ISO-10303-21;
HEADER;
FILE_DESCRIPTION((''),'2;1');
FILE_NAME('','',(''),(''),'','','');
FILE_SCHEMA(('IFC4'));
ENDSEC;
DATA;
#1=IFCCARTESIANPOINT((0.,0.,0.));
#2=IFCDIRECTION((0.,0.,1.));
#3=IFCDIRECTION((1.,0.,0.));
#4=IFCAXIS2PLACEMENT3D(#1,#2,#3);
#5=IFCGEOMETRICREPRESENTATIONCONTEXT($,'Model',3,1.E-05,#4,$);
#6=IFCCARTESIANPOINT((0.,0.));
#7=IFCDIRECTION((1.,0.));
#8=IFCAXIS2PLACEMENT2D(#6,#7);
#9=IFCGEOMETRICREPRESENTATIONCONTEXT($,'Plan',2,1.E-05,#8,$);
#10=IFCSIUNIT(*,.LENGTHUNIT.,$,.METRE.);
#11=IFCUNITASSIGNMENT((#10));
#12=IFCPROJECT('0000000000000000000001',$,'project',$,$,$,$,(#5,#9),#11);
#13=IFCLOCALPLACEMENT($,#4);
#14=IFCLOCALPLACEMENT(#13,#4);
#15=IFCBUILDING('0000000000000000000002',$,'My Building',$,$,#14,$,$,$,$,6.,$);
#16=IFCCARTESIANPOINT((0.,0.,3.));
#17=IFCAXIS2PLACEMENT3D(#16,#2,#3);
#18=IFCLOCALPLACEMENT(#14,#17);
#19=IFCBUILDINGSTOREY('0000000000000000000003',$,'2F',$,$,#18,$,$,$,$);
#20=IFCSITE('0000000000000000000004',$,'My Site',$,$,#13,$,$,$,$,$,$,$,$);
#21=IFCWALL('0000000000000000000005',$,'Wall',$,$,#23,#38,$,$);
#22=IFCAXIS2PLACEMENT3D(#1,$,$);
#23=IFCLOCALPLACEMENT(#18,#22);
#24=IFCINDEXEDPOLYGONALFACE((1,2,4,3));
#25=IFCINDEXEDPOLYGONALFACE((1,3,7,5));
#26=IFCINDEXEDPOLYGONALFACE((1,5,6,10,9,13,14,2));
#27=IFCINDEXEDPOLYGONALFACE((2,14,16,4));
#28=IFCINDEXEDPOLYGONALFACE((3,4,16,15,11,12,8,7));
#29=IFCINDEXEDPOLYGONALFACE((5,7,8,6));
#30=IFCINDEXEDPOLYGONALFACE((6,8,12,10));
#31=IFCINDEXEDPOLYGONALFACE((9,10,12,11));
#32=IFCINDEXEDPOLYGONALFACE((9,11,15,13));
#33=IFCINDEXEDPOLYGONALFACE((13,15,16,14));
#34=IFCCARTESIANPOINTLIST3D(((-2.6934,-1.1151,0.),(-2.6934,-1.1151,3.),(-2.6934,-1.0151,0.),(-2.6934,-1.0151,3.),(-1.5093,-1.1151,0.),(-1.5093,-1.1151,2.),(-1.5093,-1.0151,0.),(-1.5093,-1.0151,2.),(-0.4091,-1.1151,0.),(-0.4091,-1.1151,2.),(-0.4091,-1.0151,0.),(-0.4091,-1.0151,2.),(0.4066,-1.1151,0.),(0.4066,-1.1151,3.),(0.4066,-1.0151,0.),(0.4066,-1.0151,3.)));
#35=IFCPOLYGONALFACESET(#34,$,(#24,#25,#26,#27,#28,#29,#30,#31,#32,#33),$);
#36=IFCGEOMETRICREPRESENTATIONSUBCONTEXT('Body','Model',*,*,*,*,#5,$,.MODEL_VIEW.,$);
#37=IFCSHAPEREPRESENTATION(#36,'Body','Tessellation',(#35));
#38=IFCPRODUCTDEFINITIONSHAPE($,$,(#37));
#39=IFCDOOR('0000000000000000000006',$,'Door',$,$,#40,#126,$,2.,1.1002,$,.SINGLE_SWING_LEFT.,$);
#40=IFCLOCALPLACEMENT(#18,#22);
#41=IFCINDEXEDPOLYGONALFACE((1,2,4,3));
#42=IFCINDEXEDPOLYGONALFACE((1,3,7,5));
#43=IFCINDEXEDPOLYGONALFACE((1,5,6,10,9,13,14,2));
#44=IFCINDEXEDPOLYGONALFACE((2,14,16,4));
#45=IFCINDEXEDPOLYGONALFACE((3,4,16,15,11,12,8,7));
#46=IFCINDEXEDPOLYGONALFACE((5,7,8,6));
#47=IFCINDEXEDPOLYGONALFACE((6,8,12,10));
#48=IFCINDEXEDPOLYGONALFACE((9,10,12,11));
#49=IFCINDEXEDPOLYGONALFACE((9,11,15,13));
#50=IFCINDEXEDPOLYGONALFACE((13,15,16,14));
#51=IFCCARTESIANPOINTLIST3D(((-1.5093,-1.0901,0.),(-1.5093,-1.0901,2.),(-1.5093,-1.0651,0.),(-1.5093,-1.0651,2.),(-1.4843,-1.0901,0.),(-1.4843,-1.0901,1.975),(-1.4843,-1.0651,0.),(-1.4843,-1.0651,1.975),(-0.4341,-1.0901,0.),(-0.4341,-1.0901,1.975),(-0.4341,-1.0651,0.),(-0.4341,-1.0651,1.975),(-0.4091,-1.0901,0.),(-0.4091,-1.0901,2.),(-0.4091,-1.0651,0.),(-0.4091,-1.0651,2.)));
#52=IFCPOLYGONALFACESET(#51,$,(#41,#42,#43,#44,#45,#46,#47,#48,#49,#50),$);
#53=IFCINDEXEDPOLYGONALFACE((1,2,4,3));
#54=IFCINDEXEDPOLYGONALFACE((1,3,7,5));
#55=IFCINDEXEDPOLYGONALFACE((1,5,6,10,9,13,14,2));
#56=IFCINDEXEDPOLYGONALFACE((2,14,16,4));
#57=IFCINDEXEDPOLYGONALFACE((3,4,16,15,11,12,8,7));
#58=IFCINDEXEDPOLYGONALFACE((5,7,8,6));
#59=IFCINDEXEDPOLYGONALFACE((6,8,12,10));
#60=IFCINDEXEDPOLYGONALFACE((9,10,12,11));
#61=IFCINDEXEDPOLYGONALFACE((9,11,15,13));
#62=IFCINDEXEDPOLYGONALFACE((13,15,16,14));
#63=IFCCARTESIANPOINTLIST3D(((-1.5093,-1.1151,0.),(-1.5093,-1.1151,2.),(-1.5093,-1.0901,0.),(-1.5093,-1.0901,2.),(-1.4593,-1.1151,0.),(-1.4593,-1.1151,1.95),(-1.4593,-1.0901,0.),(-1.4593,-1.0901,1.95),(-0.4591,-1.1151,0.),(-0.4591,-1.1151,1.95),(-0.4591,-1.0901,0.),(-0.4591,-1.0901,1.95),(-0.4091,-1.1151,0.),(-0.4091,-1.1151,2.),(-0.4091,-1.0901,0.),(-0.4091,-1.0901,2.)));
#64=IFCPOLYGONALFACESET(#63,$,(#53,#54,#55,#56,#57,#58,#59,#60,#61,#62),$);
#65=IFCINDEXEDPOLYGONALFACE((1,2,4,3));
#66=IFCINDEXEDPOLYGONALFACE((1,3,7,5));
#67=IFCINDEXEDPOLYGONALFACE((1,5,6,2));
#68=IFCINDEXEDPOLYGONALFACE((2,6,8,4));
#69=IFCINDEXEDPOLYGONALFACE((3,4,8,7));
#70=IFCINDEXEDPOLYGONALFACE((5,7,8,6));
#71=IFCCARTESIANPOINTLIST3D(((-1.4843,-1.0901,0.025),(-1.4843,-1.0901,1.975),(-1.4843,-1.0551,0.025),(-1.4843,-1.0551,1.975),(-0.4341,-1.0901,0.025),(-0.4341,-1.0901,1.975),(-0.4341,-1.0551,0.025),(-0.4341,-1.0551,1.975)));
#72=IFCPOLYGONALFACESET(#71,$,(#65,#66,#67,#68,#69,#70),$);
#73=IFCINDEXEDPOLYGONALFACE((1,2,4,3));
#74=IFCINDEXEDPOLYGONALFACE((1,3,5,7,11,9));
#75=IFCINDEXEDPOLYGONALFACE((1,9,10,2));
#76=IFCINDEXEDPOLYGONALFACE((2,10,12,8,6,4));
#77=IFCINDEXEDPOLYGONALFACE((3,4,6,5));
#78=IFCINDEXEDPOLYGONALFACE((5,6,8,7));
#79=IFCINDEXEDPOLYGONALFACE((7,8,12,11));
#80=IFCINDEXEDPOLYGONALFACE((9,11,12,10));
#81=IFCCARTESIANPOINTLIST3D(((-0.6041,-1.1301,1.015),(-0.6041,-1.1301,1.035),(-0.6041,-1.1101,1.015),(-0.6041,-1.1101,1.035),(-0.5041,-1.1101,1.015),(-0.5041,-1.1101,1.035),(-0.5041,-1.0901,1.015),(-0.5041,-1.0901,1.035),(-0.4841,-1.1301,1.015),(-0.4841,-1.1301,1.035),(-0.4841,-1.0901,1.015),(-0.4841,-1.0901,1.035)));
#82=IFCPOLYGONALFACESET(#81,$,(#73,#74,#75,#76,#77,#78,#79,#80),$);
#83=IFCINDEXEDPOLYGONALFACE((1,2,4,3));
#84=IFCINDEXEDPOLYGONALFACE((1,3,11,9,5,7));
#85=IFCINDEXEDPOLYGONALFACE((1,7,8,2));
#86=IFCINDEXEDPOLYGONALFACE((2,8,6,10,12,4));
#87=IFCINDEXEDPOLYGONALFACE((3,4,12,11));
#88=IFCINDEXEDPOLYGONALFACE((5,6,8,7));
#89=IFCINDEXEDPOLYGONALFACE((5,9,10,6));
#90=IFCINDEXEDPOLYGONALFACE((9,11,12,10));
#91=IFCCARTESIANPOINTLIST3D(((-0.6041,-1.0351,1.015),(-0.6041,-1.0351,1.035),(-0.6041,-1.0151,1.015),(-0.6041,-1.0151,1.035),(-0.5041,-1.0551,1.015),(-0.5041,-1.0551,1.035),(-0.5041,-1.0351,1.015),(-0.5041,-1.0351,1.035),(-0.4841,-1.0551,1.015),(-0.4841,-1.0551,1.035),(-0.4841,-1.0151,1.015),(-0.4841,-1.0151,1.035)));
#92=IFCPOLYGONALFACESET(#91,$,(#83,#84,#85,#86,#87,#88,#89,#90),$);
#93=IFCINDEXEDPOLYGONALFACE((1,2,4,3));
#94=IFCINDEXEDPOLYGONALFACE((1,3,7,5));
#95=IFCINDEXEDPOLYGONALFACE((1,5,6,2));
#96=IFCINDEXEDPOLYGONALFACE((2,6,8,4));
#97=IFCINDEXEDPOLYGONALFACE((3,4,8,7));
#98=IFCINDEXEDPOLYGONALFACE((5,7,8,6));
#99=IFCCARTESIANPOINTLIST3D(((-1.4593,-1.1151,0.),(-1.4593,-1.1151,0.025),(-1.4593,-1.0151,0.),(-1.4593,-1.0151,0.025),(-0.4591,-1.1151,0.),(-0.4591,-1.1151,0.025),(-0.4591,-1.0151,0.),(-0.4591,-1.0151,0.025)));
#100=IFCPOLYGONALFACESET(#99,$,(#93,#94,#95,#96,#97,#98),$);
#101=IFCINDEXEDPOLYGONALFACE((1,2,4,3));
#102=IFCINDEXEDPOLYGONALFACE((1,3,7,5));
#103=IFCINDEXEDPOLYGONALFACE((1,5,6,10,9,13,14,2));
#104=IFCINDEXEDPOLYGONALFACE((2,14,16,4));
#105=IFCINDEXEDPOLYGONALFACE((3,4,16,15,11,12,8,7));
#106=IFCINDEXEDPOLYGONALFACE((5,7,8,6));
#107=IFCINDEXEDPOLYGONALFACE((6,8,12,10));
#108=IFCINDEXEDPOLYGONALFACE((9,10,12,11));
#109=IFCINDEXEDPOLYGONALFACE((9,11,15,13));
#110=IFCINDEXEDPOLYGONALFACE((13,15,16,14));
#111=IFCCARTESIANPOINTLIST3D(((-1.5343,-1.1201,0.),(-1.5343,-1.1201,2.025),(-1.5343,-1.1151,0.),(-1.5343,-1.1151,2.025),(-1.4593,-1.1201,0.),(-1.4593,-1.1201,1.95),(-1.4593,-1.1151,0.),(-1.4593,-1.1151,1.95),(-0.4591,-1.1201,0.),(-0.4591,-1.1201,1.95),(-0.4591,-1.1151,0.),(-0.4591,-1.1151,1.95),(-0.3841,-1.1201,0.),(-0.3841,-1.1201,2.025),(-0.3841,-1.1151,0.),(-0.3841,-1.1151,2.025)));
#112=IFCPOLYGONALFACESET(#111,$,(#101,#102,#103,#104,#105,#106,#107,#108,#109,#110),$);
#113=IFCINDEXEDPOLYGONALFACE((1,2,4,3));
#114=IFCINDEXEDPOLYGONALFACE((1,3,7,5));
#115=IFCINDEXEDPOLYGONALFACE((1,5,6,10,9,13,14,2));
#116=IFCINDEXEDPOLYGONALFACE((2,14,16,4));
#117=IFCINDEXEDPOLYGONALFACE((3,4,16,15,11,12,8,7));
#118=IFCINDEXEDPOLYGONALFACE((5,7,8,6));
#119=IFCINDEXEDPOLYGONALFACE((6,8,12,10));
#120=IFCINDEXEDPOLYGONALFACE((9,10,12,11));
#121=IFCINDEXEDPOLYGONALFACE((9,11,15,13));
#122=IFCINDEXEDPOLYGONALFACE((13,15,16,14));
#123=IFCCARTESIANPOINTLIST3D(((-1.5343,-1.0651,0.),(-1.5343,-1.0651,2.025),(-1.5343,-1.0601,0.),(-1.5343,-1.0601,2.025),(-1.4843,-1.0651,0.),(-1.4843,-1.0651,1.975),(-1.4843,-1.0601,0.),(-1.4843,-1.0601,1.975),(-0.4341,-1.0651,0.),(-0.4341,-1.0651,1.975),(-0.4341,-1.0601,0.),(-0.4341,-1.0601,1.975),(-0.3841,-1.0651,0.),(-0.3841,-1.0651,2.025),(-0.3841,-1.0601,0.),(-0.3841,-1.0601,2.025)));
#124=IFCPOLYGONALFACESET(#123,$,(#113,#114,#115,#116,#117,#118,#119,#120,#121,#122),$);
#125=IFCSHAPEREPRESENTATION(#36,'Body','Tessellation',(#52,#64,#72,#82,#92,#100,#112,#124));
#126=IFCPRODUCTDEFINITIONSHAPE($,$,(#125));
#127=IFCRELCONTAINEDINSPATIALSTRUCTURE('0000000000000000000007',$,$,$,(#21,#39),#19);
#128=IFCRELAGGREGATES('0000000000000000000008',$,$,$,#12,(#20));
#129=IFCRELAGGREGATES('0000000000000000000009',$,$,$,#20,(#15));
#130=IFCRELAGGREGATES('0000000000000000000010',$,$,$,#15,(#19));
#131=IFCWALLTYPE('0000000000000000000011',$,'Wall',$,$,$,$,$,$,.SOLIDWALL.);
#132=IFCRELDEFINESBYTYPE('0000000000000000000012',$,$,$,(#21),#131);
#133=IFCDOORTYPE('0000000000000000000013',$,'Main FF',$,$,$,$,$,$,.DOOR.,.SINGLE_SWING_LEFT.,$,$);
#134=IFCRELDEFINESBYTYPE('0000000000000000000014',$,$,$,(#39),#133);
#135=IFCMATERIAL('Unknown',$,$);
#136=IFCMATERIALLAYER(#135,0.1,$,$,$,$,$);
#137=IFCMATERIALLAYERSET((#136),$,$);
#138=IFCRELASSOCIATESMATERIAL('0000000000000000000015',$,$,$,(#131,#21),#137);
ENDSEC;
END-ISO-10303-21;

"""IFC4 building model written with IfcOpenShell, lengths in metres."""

from ifc_helpers import new_model, entity, si_unit, frame, origin_with_axes, origin_2d_with_axis, place, context, subcontext, project, spatial, line, indexed_curve, outline, extrude, shape, source, transform, mapped, material, layer, layer_set, layer_usage, type_object, type_shapes, element, fill, save


model = new_model("IFC4")

# Units and contexts
model_context = context("Model", 3, precision=1e-05, world=origin_with_axes())
plan_context = context("Plan", 2, precision=1e-05, world=origin_2d_with_axis())
body_context_1 = subcontext(model_context, "Body", "Model", "MODEL_VIEW")
body_context_2 = subcontext(plan_context, "Body", "Plan", "PLAN_VIEW")
ifc_project = project(units=[si_unit("LENGTHUNIT", "METRE")], contexts=[model_context, plan_context])

# Site, building, storey
site_placement = place(None, origin_with_axes())
site = spatial("IfcSite", under=ifc_project, at=site_placement, Name="My Site")
building_placement = place(site_placement, origin_with_axes())
building = spatial("IfcBuilding", under=site, at=building_placement, Name="My Building", ElevationOfTerrain=6.0)
storey_placement = place(building_placement, frame((0.0, 0.0, 3.0), z_axis=(0.0, 0.0, 1.0), x_axis=(1.0, 0.0, 0.0)))
storey = spatial("IfcBuildingStorey", under=building, at=storey_placement, Name="2F")

# Shared definitions
ifc_material_1 = material(Name="Unknown")

# Shared definitions
ifc_layer_1 = layer(ifc_material_1, 0.1)
ifc_layer_set_1 = layer_set([ifc_layer_1])
wall_type = type_object("IfcWallType", Name="Wall", PredefinedType="SOLIDWALL", material=ifc_layer_set_1)

# Wall, opening, door
ifc_layer_usage_1 = layer_usage(ifc_layer_set_1, "AXIS2", "POSITIVE", 0.0)
wall_1_placement = place(storey_placement, frame((-2.6934, -1.1151, 0.0), z_axis=(0.0, 0.0, 1.0), x_axis=(1.0, 0.0, 0.0)))
wall_1 = element("IfcWall", 1, at=wall_1_placement, inside=storey, type_object=wall_type, material=ifc_layer_usage_1, Name="Wall", context=body_context_1, shape_type="SweptSolid", body=[
    extrude(outline(indexed_curve([(0.0, 0.0), (0.0, 0.1), (3.1, 0.1), (3.1, 0.0)], segments=[line(1, 2, 3, 4, 1)])), origin_with_axes(), (0.0, 0.0, 1.0), 3.0),
])
shared_shape_1 = source(origin_with_axes(), body_context_1, "Body", "SweptSolid", [
    extrude(outline(indexed_curve([(0.0, 0.0), (1.1002, 0.0), (1.1002, 2.0), (0.0, 2.0)], segments=[line(1, 2, 3, 4, 1)])), frame((0.0, -0.6, 0.0), z_axis=(0.0, -1.0, 0.0), x_axis=(1.0, 0.0, 0.0)), (0.0, 0.0, -1.0), 1.2),
])
opening_1_placement = place(wall_1_placement, frame((1.1841, 0.0, 0.0), z_axis=(0.0, 0.0, 1.0), x_axis=(1.0, 0.0, 0.0)))
opening_1 = element("IfcOpeningElement", 2, at=opening_1_placement, cuts=wall_1, PredefinedType="OPENING", context=body_context_1, shape_type="MappedRepresentation", body=[
    mapped(shared_shape_1, transform((0.0, 0.0, 0.0), x_axis=(1.0, 0.0, 0.0), y_axis=(0.0, 1.0, 0.0), z_axis=(0.0, 0.0, 1.0), scale=1.0)),
])
door_type_1 = type_object("IfcDoorType", Name="Main FF", OperationType="SINGLE_SWING_LEFT", PredefinedType="DOOR")
shared_shape_2 = source(origin_with_axes(), body_context_1, "Body", "SweptSolid", [
    extrude(outline(indexed_curve([(0.0, 0.0), (0.0, 2.0), (1.1002, 2.0), (1.1002, 0.0), (1.0752, 0.0), (1.0752, 1.975), (0.025, 1.975), (0.025, 0.0)], segments=[line(1, 2, 3, 4, 5, 6, 7, 8, 1)])), frame((0.0, 0.025, 0.0), z_axis=(0.0, -1.0, 0.0), x_axis=(1.0, 0.0, 0.0)), (0.0, 0.0, -1.0), 0.025),
    extrude(outline(indexed_curve([(0.0, 0.0), (0.0, 2.0), (1.1002, 2.0), (1.1002, 0.0), (1.0502, 0.0), (1.0502, 1.95), (0.05, 1.95), (0.05, 0.0)], segments=[line(1, 2, 3, 4, 5, 6, 7, 8, 1)])), frame((0.0, 0.0, 0.0), z_axis=(0.0, -1.0, 0.0), x_axis=(1.0, 0.0, 0.0)), (0.0, 0.0, -1.0), 0.025),
    extrude(outline(indexed_curve([(0.0, 0.0), (1.0502, 0.0), (1.0502, 0.035), (0.0, 0.035)], segments=[line(1, 2, 3, 4, 1)])), frame((0.025, 0.025, 0.025), z_axis=(0.0, 0.0, 1.0), x_axis=(1.0, 0.0, 0.0)), (0.0, 0.0, 1.0), 1.95),
    extrude(outline(indexed_curve([(0.0, 0.0), (0.0, -0.04), (-0.12, -0.04), (-0.12, -0.02), (-0.02, -0.02), (-0.02, 0.0)], segments=[line(1, 2, 3, 4, 5, 6, 1)])), frame((1.0252, 0.025, 1.015), z_axis=(0.0, 0.0, 1.0), x_axis=(1.0, 0.0, 0.0)), (0.0, 0.0, 1.0), 0.02),
    extrude(outline(indexed_curve([(0.0, 0.0), (0.0, 0.04), (-0.12, 0.04), (-0.12, 0.02), (-0.02, 0.02), (-0.02, 0.0)], segments=[line(1, 2, 3, 4, 5, 6, 1)])), frame((1.0252, 0.06, 1.015), z_axis=(0.0, 0.0, 1.0), x_axis=(1.0, 0.0, 0.0)), (0.0, 0.0, 1.0), 0.02),
    extrude(outline(indexed_curve([(0.0, 0.0), (1.0002, 0.0), (1.0002, 0.1), (0.0, 0.1)], segments=[line(1, 2, 3, 4, 1)])), frame((0.05, 0.0, 0.0), z_axis=(0.0, 0.0, 1.0), x_axis=(1.0, 0.0, 0.0)), (0.0, 0.0, 1.0), 0.025),
    extrude(outline(indexed_curve([(0.0, 0.0), (0.0, 2.025), (1.1502, 2.025), (1.1502, 0.0), (1.0752, 0.0), (1.0752, 1.95), (0.075, 1.95), (0.075, 0.0)], segments=[line(1, 2, 3, 4, 5, 6, 7, 8, 1)])), frame((-0.025, -0.005, 0.0), z_axis=(0.0, -1.0, 0.0), x_axis=(1.0, 0.0, 0.0)), (0.0, 0.0, -1.0), 0.005),
    extrude(outline(indexed_curve([(0.0, 0.0), (0.0, 2.025), (1.1502, 2.025), (1.1502, 0.0), (1.1002, 0.0), (1.1002, 1.975), (0.05, 1.975), (0.05, 0.0)], segments=[line(1, 2, 3, 4, 5, 6, 7, 8, 1)])), frame((-0.025, 0.05, 0.0), z_axis=(0.0, -1.0, 0.0), x_axis=(1.0, 0.0, 0.0)), (0.0, 0.0, -1.0), 0.005),
])
shared_shape_3 = source(origin_with_axes(), body_context_2, "Body", "Curve2D", [
    entity("IfcIndexedPolyCurve", entity("IfcCartesianPointList2D", [[0.0, 0.0], [0.0, 0.05], [0.025, 0.05], [0.025, 0.025], [0.05, 0.025], [0.05, 0.0]]), [entity("IfcLineIndex", [1, 2, 3, 4, 5, 6, 1])]),
    entity("IfcIndexedPolyCurve", entity("IfcCartesianPointList2D", [[1.1002, 0.0], [1.1002, 0.05], [1.0752, 0.05], [1.0752, 0.025], [1.0502, 0.025], [1.0502, 0.0]]), [entity("IfcLineIndex", [1, 2, 3, 4, 5, 6, 1])]),
    entity("IfcTrimmedCurve", entity("IfcEllipse", entity("IfcAxis2Placement2D", entity("IfcCartesianPoint", [0.06, 0.05]), entity("IfcDirection", [1.0, 0.0])), 1.0152, 1.0502), [entity("IfcCartesianPoint", [1.0752, 0.05])], [entity("IfcCartesianPoint", [0.06, 1.1002])], True, "CARTESIAN"),
    entity("IfcIndexedPolyCurve", entity("IfcCartesianPointList2D", [[0.025, 0.05], [0.06, 0.05], [0.06, 1.1002], [0.025, 1.1002]]), [entity("IfcLineIndex", [1, 2, 3, 4, 1])]),
])
type_shapes(door_type_1, [shared_shape_2, shared_shape_3])
door_1_placement = place(opening_1_placement, origin_with_axes())
door_1 = element("IfcDoor", 3, at=door_1_placement, inside=storey, type_object=door_type_1, Name="Door", OperationType="SINGLE_SWING_LEFT", OverallHeight=2.0, OverallWidth=1.1002, shapes=[
    shape(body_context_1, "Body", "MappedRepresentation", [mapped(shared_shape_2, transform((0.0, 0.0, 0.0), x_axis=(1.0, 0.0, 0.0), y_axis=(0.0, 1.0, 0.0), z_axis=(0.0, 0.0, 1.0), scale=1.0))]),
    shape(body_context_2, "Body", "MappedRepresentation", [mapped(shared_shape_3, transform((0.0, 0.0, 0.0), x_axis=(1.0, 0.0, 0.0), y_axis=(0.0, 1.0, 0.0), z_axis=(0.0, 0.0, 1.0), scale=1.0))]),
])
fill(opening_1, door_1)

save(model, "model.ifc")
